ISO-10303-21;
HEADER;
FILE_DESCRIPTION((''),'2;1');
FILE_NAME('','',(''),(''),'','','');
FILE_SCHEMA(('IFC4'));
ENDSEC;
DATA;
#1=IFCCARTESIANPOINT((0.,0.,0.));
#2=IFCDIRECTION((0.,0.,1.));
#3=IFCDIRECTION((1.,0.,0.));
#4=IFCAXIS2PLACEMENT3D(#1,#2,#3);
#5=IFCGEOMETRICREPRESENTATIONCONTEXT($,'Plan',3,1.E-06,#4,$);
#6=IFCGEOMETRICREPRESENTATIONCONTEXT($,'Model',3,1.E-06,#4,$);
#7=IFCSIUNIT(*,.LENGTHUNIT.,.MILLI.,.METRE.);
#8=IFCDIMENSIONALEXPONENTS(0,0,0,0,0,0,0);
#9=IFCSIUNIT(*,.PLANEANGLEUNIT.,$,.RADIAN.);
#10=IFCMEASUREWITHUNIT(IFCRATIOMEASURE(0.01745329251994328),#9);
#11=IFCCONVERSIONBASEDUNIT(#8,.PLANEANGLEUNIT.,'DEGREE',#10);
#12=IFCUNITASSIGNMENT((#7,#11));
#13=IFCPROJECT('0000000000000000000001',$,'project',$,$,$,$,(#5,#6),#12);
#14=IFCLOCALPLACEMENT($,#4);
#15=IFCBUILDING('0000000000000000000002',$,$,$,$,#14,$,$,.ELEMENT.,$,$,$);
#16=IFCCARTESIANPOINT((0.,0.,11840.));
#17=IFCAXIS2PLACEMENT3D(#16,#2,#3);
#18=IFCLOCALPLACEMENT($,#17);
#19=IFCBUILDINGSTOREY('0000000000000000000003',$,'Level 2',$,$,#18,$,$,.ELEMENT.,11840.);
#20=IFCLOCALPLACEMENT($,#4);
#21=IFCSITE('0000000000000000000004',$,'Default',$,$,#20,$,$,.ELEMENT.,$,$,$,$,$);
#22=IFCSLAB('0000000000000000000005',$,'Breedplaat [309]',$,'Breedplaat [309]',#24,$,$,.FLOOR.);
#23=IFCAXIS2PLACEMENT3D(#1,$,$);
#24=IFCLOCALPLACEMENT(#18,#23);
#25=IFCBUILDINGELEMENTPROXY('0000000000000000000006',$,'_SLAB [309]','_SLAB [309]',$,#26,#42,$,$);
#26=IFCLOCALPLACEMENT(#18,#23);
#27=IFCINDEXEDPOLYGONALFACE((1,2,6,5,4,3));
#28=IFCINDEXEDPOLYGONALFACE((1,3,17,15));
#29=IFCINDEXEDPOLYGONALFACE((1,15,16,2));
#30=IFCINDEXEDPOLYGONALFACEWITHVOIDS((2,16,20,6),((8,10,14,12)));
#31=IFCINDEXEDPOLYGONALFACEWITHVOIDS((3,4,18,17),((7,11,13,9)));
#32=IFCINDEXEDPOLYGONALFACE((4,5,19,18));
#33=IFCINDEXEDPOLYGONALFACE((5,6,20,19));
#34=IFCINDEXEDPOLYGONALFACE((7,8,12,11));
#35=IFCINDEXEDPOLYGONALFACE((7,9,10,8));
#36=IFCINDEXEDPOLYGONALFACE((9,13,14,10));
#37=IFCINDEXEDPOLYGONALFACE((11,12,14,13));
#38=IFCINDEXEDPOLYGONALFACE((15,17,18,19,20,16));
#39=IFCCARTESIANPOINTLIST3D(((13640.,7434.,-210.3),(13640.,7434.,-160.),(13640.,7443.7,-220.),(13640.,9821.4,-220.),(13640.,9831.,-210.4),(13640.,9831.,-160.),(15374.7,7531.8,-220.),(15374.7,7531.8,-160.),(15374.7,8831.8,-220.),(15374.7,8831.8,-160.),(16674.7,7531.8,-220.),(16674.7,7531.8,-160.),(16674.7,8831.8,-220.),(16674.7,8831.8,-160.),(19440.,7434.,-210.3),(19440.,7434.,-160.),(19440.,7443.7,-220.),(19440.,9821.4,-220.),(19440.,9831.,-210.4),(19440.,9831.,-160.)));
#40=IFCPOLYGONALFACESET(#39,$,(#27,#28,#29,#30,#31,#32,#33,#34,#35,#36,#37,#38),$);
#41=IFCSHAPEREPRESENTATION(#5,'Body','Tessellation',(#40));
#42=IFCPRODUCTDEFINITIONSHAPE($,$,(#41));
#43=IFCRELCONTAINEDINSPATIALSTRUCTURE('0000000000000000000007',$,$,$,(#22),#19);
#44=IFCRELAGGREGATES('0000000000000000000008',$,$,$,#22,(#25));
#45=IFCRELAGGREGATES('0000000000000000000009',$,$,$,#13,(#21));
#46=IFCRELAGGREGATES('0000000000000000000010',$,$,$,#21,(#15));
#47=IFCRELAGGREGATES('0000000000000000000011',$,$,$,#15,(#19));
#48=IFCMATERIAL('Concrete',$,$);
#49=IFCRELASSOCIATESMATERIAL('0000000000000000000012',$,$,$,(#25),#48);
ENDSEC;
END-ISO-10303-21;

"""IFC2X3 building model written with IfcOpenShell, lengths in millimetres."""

from ifc_helpers import new_model, entity, si_unit, converted_unit, frame, origin_with_axes, origin_2d_with_axis, place, context, project, spatial, polyline, rectangle, outline, extrude, material, element, aggregate, save


model = new_model("IFC2X3")

# Units and contexts
plan_context = context("Plan", 3, precision=1e-06, world=origin_with_axes())
model_context = context("Model", 3, precision=1e-06, world=origin_with_axes())
ifc_project = project(units=[si_unit("LENGTHUNIT", "METRE", prefix="MILLI"), converted_unit("PLANEANGLEUNIT", "DEGREE", entity("IfcRatioMeasure", 0.01745329251994328), si_unit("PLANEANGLEUNIT", "RADIAN"), dimensions=[0, 0, 0, 0, 0, 0, 0])], contexts=[plan_context, model_context])

# Site, building, storey
site_placement = place(None, origin_with_axes())
site = spatial("IfcSite", under=ifc_project, at=site_placement, Name="Default", CompositionType="ELEMENT")
building_placement = place(None, origin_with_axes())
building = spatial("IfcBuilding", under=site, at=building_placement, CompositionType="ELEMENT")
storey_placement = place(None, frame((0.0, 0.0, 11840.0), z_axis=(0.0, 0.0, 1.0), x_axis=(1.0, 0.0, 0.0)))
storey = spatial("IfcBuildingStorey", under=building, at=storey_placement, Name="Level 2", CompositionType="ELEMENT", Elevation=11840.0)

# Slab, building element proxy, openings
slab_1_placement = place(None, frame((13640.0, 7434.0, 11620.0), z_axis=(0.0, 0.0, 1.0), x_axis=(1.0, 0.0, 0.0)))
slab_1 = element("IfcSlab", 1, at=slab_1_placement, inside=storey, Name="Breedplaat [309]", ObjectType="Breedplaat [309]", PredefinedType="FLOOR")
ifc_material_1 = material(Name="Concrete")
proxy_1_placement = place(slab_1_placement, origin_with_axes())
proxy_1 = element("IfcBuildingElementProxy", 2, at=proxy_1_placement, material=ifc_material_1, Name="_SLAB [309]", Description="_SLAB [309]", context=plan_context, shape_type="SweptSolid", body=[
    extrude(outline(polyline([(5800.0, 0.0), (5800.0, 2397.0), (0.0, 2397.0), (0.0, 0.0), (5800.0, 0.0)])), origin_with_axes(), (0.0, 0.0, 1.0), 60.0),
])
opening_1_placement = place(slab_1_placement, frame((1734.8, 97.8, 0.0), z_axis=(0.0, 0.0, 1.0), x_axis=(1.0, 0.0, 0.0)))
element("IfcOpeningElement", 3, at=opening_1_placement, cuts=proxy_1, ObjectType="Opening", context=plan_context, shape_type="SolidModel", body=[
    extrude(rectangle(XDim=1300.0, YDim=1300.0, at=origin_2d_with_axis()), frame((650.0, 650.0, 0.0), z_axis=(0.0, 0.0, 1.0), x_axis=(1.0, 0.0, 0.0)), (0.0, 0.0, 1.0), 60.0),
])
opening_2_placement = place(None, frame((13640.0, 7434.0, 11620.0), z_axis=(0.0, 0.0, 1.0), x_axis=(1.0, 0.0, 0.0)))
element("IfcOpeningElement", 4, at=opening_2_placement, cuts=proxy_1, ObjectType="Opening", context=plan_context, shape_type="SweptSolid", body=[
    extrude(outline(polyline([(-0.1, -0.1), (-0.1, 10.0), (10.0, -0.1), (-0.1, -0.1)])), frame((-1.2, -0.1, -0.1), z_axis=(1.0, 0.0, 0.0), x_axis=(0.0, 1.0, 0.0)), (0.0, 0.0, 1.0), 5802.2),
])
opening_3_placement = place(None, frame((13640.0, 7434.0, 11620.0), z_axis=(0.0, 0.0, 1.0), x_axis=(1.0, 0.0, 0.0)))
element("IfcOpeningElement", 5, at=opening_3_placement, cuts=proxy_1, ObjectType="Opening", context=plan_context, shape_type="SweptSolid", body=[
    extrude(outline(polyline([(-0.1, -0.1), (-0.1, 10.0), (10.0, -0.1), (-0.1, -0.1)])), frame((5801.2, 2397.2, -0.1), z_axis=(-1.0, 0.0, 0.0), x_axis=(0.0, -1.0, 0.0)), (0.0, 0.0, 1.0), 5802.2),
])
aggregate(slab_1, [proxy_1])

save(model, "model.ifc")
